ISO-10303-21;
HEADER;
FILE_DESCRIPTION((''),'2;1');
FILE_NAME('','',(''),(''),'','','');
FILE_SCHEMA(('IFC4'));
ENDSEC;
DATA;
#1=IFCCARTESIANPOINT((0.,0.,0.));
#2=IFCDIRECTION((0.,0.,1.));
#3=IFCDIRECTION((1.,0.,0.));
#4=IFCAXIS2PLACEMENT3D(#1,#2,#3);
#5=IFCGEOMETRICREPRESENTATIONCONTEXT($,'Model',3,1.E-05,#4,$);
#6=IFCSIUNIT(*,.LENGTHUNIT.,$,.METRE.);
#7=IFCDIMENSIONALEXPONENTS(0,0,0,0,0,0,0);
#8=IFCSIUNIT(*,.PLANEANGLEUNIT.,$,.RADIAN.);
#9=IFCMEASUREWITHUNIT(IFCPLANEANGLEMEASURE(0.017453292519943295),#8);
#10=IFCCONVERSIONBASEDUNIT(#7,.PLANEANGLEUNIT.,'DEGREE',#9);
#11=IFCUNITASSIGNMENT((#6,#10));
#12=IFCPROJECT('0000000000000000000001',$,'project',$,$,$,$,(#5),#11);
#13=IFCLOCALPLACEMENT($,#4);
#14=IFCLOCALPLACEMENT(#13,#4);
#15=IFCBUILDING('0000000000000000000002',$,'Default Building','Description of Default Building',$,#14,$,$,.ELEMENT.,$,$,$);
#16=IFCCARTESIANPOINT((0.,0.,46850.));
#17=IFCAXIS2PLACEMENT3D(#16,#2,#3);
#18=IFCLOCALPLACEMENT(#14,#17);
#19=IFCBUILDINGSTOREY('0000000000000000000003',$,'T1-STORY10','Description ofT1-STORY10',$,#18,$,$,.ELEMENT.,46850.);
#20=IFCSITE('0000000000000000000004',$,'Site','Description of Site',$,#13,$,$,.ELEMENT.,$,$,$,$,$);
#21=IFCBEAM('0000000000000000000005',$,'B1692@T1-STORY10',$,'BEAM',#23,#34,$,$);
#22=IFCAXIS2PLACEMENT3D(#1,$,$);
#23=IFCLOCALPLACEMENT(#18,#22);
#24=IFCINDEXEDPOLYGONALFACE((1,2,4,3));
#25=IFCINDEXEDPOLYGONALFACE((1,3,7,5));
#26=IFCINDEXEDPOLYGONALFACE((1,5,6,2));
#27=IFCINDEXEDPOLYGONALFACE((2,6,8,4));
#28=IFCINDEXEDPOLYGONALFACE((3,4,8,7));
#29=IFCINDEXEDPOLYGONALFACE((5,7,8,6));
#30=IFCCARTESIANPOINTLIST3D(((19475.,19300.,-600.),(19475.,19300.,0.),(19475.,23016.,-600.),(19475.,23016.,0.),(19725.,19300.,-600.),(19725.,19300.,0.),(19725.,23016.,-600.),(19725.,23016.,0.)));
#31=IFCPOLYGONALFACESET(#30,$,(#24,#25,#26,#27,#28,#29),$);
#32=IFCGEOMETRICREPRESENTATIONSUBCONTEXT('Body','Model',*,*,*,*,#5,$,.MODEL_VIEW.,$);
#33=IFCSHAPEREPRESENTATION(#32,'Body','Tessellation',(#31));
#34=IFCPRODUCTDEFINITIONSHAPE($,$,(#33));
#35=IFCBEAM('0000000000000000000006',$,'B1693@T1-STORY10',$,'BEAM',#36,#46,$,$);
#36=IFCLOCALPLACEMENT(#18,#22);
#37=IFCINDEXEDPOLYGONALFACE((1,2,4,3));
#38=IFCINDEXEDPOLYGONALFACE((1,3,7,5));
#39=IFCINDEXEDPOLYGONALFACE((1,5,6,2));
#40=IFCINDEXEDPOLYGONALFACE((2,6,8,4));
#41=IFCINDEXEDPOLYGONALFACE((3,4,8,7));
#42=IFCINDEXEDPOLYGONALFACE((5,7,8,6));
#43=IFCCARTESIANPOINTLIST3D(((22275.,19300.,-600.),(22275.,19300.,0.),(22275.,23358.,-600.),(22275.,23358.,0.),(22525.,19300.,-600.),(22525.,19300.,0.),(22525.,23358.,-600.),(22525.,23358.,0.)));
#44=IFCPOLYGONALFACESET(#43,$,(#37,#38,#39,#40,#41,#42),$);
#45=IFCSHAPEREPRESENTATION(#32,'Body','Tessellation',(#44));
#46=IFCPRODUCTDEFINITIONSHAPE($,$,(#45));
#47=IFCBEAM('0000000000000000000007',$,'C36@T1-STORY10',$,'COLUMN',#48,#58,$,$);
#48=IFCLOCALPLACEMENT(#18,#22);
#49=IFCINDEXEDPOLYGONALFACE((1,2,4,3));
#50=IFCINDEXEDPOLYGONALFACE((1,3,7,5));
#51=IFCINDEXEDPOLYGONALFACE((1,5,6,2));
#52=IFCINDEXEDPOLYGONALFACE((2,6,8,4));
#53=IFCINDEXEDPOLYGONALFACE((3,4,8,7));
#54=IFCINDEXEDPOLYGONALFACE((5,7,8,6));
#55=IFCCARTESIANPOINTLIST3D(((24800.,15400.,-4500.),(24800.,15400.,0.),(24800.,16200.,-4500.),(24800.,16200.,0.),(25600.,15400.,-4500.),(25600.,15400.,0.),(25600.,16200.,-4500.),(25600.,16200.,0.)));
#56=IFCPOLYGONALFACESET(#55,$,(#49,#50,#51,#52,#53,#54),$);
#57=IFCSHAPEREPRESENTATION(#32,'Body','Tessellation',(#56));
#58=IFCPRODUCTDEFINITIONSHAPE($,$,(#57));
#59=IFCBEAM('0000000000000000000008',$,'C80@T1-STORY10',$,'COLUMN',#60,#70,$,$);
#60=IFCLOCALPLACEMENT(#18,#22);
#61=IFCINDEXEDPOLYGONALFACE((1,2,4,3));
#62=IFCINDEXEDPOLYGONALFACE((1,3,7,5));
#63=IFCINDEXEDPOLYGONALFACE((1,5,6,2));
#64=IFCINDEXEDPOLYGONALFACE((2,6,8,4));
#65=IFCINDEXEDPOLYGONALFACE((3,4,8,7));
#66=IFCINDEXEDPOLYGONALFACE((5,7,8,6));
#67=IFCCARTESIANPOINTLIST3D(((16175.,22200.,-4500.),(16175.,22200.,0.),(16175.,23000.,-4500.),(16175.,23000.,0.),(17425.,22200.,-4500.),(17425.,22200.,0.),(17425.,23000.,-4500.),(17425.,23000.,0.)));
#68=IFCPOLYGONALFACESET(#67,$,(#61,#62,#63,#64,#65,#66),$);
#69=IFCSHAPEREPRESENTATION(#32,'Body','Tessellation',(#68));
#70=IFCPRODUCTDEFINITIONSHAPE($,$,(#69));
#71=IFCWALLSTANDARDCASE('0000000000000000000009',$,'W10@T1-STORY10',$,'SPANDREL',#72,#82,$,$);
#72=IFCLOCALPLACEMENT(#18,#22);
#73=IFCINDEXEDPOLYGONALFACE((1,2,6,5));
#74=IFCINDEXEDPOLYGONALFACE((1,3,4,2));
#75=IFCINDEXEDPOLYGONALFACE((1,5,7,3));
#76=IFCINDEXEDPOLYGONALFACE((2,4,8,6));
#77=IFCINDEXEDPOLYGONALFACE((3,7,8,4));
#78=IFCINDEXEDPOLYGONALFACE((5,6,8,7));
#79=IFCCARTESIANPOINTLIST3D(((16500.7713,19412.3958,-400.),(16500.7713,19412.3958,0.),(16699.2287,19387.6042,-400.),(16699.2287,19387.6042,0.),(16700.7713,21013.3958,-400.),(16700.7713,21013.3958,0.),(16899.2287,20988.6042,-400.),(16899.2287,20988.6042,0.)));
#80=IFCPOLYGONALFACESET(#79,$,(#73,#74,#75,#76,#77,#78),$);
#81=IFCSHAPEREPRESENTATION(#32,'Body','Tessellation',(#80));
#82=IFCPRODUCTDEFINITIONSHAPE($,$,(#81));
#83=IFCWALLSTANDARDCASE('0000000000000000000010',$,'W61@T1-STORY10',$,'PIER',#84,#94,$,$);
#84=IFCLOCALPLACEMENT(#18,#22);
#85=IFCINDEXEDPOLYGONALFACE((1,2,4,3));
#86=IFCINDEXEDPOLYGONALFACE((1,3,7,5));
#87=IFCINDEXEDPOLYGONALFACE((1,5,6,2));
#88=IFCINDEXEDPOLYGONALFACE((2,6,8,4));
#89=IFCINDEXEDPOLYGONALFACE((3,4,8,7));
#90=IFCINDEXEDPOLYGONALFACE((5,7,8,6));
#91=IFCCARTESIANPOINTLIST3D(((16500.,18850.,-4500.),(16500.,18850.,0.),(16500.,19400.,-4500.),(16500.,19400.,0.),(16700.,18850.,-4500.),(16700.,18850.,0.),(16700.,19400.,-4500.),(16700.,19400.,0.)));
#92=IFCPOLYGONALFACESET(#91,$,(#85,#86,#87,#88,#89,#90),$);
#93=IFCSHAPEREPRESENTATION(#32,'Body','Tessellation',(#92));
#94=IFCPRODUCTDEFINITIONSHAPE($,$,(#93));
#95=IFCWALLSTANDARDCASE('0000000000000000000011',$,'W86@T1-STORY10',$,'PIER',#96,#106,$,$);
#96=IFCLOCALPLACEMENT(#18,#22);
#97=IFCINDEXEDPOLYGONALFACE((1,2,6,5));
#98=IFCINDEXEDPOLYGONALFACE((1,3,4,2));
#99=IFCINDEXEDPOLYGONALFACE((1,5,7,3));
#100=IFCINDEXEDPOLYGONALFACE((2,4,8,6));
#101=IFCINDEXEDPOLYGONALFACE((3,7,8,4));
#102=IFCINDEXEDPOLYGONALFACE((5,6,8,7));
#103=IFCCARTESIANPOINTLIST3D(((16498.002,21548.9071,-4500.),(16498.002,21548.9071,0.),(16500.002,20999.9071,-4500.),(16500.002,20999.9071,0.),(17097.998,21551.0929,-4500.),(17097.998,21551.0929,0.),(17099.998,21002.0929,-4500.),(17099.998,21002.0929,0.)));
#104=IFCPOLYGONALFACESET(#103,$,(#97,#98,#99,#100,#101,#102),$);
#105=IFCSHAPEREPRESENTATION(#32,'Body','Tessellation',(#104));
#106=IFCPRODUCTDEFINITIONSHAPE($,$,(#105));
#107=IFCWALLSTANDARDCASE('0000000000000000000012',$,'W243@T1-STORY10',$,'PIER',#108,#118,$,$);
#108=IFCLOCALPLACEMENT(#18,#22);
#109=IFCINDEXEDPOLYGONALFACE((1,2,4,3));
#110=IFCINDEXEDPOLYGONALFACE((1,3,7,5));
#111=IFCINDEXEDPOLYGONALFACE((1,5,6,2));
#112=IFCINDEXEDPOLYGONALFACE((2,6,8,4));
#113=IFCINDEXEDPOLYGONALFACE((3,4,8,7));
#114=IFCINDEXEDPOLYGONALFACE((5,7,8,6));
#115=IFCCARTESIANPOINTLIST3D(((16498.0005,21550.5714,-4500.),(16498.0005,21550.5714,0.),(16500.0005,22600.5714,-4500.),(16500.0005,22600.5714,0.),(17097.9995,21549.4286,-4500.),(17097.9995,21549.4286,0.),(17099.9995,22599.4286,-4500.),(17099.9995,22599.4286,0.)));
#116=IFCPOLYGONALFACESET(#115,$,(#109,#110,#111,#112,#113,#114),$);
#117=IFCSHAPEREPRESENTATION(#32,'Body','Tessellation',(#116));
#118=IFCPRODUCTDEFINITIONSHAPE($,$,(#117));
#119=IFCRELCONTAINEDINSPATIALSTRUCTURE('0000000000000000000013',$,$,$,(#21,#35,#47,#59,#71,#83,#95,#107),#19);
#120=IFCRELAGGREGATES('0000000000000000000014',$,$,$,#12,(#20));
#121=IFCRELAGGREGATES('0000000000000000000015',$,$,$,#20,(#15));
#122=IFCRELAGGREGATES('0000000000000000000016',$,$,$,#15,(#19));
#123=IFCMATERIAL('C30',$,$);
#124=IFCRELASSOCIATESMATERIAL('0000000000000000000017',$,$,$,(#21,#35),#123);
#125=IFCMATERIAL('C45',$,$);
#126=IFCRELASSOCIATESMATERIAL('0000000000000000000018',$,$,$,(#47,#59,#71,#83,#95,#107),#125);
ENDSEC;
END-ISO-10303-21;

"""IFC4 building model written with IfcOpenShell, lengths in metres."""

from ifc_helpers import new_model, entity, si_unit, converted_unit, frame, origin_with_axes, place, context, subcontext, project, spatial, indexed_curve, rectangle, outline, extrude, material, element, save


model = new_model("IFC4")

# Units and contexts
model_context = context("Model", 3, precision=1e-05, world=origin_with_axes())
body_context = subcontext(model_context, "Body", "Model", "MODEL_VIEW")
ifc_project = project(units=[si_unit("LENGTHUNIT", "METRE"), converted_unit("PLANEANGLEUNIT", "DEGREE", entity("IfcPlaneAngleMeasure", 0.017453292519943295), si_unit("PLANEANGLEUNIT", "RADIAN"), dimensions=[0, 0, 0, 0, 0, 0, 0])], contexts=[model_context])

# Site, building, storey
site_placement = place(None, origin_with_axes())
site = spatial("IfcSite", under=ifc_project, at=site_placement, Name="Site", Description="Description of Site", CompositionType="ELEMENT")
building_placement = place(site_placement, origin_with_axes())
building = spatial("IfcBuilding", under=site, at=building_placement, Name="Default Building", Description="Description of Default Building", CompositionType="ELEMENT")
storey_placement = place(building_placement, frame((0.0, 0.0, 46850.0), z_axis=(0.0, 0.0, 1.0), x_axis=(1.0, 0.0, 0.0)))
storey = spatial("IfcBuildingStorey", under=building, at=storey_placement, Name="T1-STORY10", Description="Description ofT1-STORY10", CompositionType="ELEMENT", Elevation=46850.0)

# Beams
ifc_material_1 = material(Name="C30")
beam_1_placement = place(storey_placement, frame((19600.0, 19300.0, -300.0), z_axis=(0.0, 1.0, 0.0), x_axis=(-1.0, 0.0, 0.0)))
element("IfcBeam", 1, at=beam_1_placement, inside=storey, material=ifc_material_1, Name="B1692@T1-STORY10", ObjectType="BEAM", context=body_context, shape_type="SweptSolid", body=[
    extrude(rectangle(XDim=250.0, YDim=600.0), origin_with_axes(), (0.0, 0.0, 1.0), 3716.0),
])
beam_2_placement = place(storey_placement, frame((22400.0, 19300.0, -300.0), z_axis=(0.0, 1.0, 0.0), x_axis=(-1.0, 0.0, 0.0)))
element("IfcBeam", 2, at=beam_2_placement, inside=storey, material=ifc_material_1, Name="B1693@T1-STORY10", ObjectType="BEAM", context=body_context, shape_type="SweptSolid", body=[
    extrude(rectangle(XDim=250.0, YDim=600.0), origin_with_axes(), (0.0, 0.0, 1.0), 4058.0),
])
ifc_material_2 = material(Name="C45")
beam_3_placement = place(storey_placement, frame((25200.0, 15800.0, -4500.0), z_axis=(0.0, 0.0, 1.0), x_axis=(-1.0, 0.0, 0.0)))
element("IfcBeam", 3, at=beam_3_placement, inside=storey, material=ifc_material_2, Name="C36@T1-STORY10", ObjectType="COLUMN", context=body_context, shape_type="SweptSolid", body=[
    extrude(rectangle(XDim=800.0, YDim=800.0), origin_with_axes(), (0.0, 0.0, 1.0), 4500.0),
])
beam_4_placement = place(storey_placement, frame((16800.0, 22600.0, -4500.0), z_axis=(0.0, 0.0, 1.0), x_axis=(0.0, -1.0, 0.0)))
element("IfcBeam", 4, at=beam_4_placement, inside=storey, material=ifc_material_2, Name="C80@T1-STORY10", ObjectType="COLUMN", context=body_context, shape_type="SweptSolid", body=[
    extrude(rectangle(XDim=800.0, YDim=1250.0), origin_with_axes(), (0.0, 0.0, 1.0), 4500.0),
])

# Walls
wall_1_placement = place(storey_placement, frame((16600.0, 19400.0, -400.0), z_axis=(0.0, 0.0, 1.0), x_axis=(0.123958, 0.992287, 0.0)))
element("IfcWallStandardCase", 5, at=wall_1_placement, inside=storey, material=ifc_material_2, Name="W10@T1-STORY10", ObjectType="SPANDREL", context=body_context, shape_type="SweptSolid", body=[
    extrude(outline(indexed_curve([(0.0, -100.0), (0.0, 100.0), (1613.4438, 100.0), (1613.4438, -100.0), (0.0, -100.0)], self_intersect=False)), origin_with_axes(), (0.0, 0.0, 1.0), 400.0),
])
wall_2_placement = place(storey_placement, frame((16600.0, 18850.0, -4500.0), z_axis=(0.0, 0.0, 1.0), x_axis=(0.0, 1.0, 0.0)))
element("IfcWallStandardCase", 6, at=wall_2_placement, inside=storey, material=ifc_material_2, Name="W61@T1-STORY10", ObjectType="PIER", context=body_context, shape_type="SweptSolid", body=[
    extrude(outline(indexed_curve([(0.0, -100.0), (0.0, 100.0), (550.0, 100.0), (550.0, -100.0), (0.0, -100.0)], self_intersect=False)), origin_with_axes(), (0.0, 0.0, 1.0), 4500.0),
])
wall_3_placement = place(storey_placement, frame((16800.0, 21001.0, -4500.0), z_axis=(0.0, 0.0, 1.0), x_axis=(-0.003643, 0.999993, 0.0)))
element("IfcWallStandardCase", 7, at=wall_3_placement, inside=storey, material=ifc_material_2, Name="W86@T1-STORY10", ObjectType="PIER", context=body_context, shape_type="SweptSolid", body=[
    extrude(outline(indexed_curve([(0.0, -300.0), (0.0, 300.0), (549.0036, 300.0), (549.0036, -300.0), (0.0, -300.0)], self_intersect=False)), origin_with_axes(), (0.0, 0.0, 1.0), 4500.0),
])
wall_4_placement = place(storey_placement, frame((16798.0, 21550.0, -4500.0), z_axis=(0.0, 0.0, 1.0), x_axis=(0.001905, 0.999998, 0.0)))
element("IfcWallStandardCase", 8, at=wall_4_placement, inside=storey, material=ifc_material_2, Name="W243@T1-STORY10", ObjectType="PIER", context=body_context, shape_type="SweptSolid", body=[
    extrude(outline(indexed_curve([(0.0, -300.0), (0.0, 300.0), (1050.0019, 300.0), (1050.0019, -300.0), (0.0, -300.0)], self_intersect=False)), origin_with_axes(), (0.0, 0.0, 1.0), 4500.0),
])

save(model, "model.ifc")
